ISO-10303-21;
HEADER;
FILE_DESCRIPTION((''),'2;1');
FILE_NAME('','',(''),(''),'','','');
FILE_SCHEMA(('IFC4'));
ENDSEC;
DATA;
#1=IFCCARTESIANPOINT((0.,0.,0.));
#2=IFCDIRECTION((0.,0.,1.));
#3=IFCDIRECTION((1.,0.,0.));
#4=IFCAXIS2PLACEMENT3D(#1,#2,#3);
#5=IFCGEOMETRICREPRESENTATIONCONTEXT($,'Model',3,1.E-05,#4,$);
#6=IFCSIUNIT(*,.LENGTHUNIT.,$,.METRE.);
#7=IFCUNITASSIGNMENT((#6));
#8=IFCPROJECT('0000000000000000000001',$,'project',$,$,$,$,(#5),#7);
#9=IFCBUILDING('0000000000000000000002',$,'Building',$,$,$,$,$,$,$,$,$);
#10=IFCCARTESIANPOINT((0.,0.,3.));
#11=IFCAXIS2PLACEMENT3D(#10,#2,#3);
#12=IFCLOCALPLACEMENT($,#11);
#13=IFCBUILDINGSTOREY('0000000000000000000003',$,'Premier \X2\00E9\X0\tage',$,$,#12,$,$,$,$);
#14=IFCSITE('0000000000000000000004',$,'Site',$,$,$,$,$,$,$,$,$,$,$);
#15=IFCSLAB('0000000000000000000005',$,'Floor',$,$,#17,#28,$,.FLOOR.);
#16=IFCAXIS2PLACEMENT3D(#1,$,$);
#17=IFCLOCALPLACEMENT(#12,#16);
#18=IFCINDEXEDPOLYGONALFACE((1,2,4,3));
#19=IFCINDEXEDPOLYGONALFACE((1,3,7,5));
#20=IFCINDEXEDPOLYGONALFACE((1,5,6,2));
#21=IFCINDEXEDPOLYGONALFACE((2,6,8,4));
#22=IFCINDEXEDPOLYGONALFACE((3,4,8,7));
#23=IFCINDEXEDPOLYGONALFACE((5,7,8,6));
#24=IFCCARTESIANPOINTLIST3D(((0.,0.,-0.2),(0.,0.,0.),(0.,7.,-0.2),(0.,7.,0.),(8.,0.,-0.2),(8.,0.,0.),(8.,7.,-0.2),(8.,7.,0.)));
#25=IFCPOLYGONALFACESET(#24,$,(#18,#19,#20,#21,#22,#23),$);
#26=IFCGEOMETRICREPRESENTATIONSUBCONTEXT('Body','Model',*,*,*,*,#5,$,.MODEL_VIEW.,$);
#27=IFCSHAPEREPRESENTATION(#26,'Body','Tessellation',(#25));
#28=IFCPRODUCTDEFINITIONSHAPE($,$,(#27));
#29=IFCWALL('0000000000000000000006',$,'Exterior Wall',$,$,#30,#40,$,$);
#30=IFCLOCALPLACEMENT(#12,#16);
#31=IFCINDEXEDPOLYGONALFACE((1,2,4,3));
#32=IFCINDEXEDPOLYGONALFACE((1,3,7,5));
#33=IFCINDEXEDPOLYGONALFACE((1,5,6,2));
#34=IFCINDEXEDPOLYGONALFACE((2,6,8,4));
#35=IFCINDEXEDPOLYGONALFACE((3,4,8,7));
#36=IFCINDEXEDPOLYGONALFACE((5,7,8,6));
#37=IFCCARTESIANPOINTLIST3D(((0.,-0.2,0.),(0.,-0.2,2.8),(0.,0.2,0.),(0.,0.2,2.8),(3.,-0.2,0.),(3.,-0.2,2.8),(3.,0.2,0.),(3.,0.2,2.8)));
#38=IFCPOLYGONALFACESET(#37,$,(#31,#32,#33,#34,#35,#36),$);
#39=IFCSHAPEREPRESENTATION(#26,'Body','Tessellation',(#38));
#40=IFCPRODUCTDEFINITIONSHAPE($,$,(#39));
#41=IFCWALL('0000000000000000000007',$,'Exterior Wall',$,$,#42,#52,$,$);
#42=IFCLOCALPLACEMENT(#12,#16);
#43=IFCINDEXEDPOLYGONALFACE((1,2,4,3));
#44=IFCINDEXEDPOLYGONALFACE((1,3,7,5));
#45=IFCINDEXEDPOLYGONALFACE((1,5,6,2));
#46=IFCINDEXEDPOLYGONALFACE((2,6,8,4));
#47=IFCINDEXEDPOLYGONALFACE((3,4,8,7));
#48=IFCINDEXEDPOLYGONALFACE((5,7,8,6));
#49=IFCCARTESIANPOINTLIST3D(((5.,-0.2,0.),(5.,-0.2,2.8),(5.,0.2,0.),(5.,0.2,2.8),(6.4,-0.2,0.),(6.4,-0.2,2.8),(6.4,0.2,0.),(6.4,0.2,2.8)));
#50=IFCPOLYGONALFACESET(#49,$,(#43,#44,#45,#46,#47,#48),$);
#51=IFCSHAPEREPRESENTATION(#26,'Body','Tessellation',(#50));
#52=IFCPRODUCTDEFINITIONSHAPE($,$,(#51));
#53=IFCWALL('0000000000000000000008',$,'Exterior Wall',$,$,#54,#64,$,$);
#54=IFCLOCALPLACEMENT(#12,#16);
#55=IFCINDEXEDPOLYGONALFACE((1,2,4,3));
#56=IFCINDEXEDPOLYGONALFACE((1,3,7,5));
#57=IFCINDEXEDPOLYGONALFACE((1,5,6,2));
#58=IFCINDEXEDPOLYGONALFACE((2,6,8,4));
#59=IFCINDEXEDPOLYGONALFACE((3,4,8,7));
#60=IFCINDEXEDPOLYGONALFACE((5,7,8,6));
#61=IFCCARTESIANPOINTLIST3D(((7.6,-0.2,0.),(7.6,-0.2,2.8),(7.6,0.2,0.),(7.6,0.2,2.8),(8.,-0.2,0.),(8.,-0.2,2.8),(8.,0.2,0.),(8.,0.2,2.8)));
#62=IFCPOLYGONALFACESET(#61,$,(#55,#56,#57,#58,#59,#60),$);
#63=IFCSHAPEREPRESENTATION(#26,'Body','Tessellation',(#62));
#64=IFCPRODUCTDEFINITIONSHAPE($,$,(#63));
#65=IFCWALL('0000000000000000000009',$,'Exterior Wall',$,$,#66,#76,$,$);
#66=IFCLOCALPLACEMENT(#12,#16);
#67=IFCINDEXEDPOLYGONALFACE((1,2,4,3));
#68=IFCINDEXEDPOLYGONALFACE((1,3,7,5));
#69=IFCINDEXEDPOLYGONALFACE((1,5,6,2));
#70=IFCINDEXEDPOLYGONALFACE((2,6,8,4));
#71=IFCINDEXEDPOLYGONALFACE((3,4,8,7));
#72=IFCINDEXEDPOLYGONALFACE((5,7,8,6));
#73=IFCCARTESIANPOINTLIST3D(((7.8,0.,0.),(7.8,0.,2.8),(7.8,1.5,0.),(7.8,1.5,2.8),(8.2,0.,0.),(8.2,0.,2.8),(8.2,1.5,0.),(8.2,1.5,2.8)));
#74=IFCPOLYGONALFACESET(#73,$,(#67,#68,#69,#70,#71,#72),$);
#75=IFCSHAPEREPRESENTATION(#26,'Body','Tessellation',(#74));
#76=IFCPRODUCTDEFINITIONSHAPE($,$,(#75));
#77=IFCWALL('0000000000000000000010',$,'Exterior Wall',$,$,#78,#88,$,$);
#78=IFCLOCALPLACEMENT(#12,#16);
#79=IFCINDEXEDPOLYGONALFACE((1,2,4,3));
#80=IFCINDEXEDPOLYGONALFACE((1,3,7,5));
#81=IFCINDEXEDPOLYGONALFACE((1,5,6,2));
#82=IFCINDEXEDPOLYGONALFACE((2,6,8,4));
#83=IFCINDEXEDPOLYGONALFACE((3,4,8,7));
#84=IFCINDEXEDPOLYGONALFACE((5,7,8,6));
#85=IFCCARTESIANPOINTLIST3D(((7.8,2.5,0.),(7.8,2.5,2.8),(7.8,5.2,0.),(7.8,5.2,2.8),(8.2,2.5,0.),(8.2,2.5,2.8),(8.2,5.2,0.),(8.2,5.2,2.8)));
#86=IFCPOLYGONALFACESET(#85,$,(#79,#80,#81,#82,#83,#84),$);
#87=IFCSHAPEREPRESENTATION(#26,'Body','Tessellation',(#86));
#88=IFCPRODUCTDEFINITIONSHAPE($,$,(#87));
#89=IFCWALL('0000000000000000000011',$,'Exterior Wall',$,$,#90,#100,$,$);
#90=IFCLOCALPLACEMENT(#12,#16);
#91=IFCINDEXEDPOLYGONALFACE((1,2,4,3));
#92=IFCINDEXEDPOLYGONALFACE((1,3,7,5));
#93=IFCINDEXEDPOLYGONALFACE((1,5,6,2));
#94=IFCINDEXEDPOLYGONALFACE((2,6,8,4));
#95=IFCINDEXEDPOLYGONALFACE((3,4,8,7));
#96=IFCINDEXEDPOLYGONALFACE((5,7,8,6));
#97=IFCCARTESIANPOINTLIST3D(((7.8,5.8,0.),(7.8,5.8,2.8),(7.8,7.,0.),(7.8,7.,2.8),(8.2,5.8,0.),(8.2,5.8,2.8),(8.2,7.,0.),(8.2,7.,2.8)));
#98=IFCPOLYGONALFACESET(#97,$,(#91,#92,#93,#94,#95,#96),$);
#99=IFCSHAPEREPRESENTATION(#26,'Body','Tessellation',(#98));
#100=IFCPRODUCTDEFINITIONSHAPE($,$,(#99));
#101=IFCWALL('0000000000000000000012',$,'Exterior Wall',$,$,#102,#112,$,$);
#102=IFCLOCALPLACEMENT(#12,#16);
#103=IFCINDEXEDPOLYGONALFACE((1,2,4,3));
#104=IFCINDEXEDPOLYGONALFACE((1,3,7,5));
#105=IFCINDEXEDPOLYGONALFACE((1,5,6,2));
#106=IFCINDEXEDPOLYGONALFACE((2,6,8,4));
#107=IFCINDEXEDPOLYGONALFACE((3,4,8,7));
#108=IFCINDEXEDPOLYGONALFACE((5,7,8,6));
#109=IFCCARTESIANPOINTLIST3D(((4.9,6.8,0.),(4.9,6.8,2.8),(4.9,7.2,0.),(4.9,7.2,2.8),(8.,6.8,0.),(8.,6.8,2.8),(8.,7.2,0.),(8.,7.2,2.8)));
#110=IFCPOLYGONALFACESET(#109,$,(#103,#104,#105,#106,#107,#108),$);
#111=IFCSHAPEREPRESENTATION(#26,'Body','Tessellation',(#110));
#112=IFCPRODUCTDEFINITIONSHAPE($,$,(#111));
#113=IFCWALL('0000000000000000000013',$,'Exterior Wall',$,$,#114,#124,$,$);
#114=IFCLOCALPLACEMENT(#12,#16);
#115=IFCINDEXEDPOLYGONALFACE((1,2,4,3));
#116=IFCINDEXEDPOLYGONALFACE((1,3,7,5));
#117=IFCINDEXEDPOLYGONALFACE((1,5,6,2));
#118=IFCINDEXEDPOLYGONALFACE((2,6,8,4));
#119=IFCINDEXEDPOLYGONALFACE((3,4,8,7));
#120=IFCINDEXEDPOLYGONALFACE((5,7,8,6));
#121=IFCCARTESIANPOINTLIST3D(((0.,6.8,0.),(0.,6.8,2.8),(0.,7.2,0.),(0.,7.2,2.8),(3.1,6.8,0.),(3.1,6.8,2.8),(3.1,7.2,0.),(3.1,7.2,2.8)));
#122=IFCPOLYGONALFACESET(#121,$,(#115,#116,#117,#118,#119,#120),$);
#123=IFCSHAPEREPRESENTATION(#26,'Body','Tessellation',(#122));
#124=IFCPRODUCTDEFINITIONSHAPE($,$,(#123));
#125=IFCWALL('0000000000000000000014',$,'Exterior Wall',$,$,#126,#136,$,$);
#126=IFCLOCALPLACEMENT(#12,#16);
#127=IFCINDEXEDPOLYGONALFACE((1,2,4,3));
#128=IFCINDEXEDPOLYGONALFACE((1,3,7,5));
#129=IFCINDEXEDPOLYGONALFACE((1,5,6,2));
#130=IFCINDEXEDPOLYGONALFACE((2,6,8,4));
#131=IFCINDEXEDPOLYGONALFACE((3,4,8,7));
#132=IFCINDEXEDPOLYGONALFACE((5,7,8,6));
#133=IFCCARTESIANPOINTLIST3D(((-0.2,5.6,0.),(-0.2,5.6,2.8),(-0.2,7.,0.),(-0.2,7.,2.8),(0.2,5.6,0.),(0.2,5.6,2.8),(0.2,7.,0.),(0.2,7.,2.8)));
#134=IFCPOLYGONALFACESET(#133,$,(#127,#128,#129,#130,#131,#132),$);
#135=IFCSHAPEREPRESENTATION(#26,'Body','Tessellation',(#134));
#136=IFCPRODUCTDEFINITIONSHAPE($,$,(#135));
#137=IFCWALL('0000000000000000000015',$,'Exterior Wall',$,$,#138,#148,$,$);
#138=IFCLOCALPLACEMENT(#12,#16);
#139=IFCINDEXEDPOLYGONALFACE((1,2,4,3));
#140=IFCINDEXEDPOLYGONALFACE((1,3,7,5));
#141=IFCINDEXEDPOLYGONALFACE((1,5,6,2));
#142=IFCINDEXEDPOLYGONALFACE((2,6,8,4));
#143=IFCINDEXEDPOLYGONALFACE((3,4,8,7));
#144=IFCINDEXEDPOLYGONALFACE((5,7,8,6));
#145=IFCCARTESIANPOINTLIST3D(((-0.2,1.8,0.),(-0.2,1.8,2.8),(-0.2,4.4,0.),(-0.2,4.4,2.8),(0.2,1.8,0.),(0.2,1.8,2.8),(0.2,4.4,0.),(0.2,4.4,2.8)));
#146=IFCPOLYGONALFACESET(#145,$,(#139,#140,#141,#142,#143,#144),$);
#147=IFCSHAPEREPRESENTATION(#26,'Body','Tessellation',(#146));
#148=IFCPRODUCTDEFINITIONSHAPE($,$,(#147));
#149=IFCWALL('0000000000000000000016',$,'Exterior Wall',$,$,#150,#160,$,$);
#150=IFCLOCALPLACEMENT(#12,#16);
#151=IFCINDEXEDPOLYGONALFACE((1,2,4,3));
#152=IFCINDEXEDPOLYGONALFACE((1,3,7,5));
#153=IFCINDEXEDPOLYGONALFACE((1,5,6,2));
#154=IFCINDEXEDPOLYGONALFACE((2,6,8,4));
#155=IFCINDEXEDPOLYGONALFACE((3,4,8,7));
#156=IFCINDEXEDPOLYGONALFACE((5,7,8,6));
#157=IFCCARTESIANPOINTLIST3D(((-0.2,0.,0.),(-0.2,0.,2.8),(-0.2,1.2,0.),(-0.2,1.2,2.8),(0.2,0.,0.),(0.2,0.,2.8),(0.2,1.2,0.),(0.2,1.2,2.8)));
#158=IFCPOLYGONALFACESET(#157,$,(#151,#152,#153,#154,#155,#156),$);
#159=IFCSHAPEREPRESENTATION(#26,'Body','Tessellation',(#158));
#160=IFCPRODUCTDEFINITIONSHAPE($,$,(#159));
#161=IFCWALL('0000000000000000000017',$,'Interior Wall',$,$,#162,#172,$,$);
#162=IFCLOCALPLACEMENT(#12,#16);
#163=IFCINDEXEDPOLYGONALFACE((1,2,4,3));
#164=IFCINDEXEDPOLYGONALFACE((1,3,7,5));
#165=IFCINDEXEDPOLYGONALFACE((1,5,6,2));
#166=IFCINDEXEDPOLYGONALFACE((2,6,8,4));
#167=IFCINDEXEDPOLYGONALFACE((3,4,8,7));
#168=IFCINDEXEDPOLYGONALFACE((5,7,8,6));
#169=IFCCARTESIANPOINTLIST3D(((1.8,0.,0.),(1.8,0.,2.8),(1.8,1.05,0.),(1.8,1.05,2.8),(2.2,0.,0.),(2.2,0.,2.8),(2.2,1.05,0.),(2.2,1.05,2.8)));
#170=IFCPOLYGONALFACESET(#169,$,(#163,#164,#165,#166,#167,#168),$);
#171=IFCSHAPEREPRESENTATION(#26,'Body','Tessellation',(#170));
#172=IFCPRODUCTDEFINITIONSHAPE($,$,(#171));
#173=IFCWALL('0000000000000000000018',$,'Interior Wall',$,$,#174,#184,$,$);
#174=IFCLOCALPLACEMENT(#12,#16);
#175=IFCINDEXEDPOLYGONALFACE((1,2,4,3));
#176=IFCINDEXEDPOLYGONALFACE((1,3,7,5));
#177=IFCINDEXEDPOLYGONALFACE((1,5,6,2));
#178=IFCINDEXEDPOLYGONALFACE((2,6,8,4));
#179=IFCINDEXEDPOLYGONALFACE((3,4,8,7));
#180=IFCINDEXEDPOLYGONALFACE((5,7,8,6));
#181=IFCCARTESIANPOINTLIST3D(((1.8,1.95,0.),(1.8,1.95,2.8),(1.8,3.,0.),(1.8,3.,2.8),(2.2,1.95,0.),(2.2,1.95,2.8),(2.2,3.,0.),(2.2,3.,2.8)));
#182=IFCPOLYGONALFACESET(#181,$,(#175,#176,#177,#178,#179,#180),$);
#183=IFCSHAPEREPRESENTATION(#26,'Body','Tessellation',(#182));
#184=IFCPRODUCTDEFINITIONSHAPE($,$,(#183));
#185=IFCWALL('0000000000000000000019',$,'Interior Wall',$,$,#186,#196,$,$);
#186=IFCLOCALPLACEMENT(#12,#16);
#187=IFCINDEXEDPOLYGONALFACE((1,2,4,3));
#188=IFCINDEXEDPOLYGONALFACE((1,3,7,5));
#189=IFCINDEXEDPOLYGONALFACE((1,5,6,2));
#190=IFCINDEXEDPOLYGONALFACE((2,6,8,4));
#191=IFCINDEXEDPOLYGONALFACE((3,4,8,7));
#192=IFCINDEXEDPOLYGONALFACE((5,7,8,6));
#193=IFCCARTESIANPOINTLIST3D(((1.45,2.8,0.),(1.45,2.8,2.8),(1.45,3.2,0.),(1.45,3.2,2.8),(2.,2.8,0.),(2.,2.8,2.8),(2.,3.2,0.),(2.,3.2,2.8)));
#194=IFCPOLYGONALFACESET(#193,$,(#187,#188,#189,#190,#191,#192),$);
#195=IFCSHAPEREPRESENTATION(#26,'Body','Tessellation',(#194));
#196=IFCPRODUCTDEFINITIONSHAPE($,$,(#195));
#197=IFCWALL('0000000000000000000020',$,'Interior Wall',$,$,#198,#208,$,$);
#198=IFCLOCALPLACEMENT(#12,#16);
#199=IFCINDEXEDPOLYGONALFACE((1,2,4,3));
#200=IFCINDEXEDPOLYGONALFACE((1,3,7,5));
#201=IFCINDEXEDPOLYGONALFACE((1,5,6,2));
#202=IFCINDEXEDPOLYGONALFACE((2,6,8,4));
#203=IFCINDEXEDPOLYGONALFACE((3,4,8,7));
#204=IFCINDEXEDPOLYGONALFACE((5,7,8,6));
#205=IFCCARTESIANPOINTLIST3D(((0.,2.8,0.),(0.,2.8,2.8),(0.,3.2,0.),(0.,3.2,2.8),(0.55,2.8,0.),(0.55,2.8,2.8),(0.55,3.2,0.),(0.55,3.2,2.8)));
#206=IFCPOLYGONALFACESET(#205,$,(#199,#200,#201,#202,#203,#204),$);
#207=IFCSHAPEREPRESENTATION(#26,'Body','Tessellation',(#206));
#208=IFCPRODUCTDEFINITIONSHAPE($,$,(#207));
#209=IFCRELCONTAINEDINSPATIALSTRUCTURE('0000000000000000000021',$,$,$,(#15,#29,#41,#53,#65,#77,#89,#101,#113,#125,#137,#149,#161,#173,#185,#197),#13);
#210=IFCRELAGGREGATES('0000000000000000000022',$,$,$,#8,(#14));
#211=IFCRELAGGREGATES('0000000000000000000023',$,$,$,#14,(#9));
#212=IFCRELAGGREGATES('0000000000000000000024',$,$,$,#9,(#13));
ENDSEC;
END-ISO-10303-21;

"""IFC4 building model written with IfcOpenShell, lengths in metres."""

from ifc_helpers import new_model, si_unit, frame, origin_with_axes, place, context, subcontext, project, spatial, indexed_curve, outline, extrude, element, save


model = new_model("IFC4")

# Units and contexts
model_context = context("Model", 3, precision=1e-05, world=origin_with_axes())
body_context = subcontext(model_context, "Body", "Model", "MODEL_VIEW")
ifc_project = project(units=[si_unit("LENGTHUNIT", "METRE")], contexts=[model_context])

# Site, building, storey
site = spatial("IfcSite", under=ifc_project, Name="Site")
building = spatial("IfcBuilding", under=site, Name="Building")
storey_placement = place(None, frame((0.0, 0.0, 3.0), z_axis=(0.0, 0.0, 1.0), x_axis=(1.0, 0.0, 0.0)))
storey = spatial("IfcBuildingStorey", under=building, at=storey_placement, Name="Premier étage")

# Slab
slab_placement = place(storey_placement, frame((0.0, 0.0, -0.2), z_axis=(0.0, 0.0, 1.0), x_axis=(1.0, 0.0, 0.0)))
element("IfcSlab", 1, at=slab_placement, inside=storey, Name="Floor", PredefinedType="FLOOR", context=body_context, shape_type="SweptSolid", body=[
    extrude(outline(indexed_curve([(0.0, 0.0), (8.0, 0.0), (8.0, 7.0), (0.0, 7.0)])), None, (0.0, 0.0, 1.0), 0.2),
])

# Walls
wall_1_placement = place(storey_placement, origin_with_axes())
element("IfcWall", 2, at=wall_1_placement, inside=storey, Name="Exterior Wall", context=body_context, shape_type="SweptSolid", body=[
    extrude(outline(indexed_curve([(0.0, 0.0), (0.0, 0.4), (3.0, 0.4), (3.0, 0.0), (0.0, 0.0)], self_intersect=False)), frame((0.0, -0.2, 0.0), z_axis=(0.0, 0.0, 1.0), x_axis=(1.0, 0.0, 0.0)), (0.0, 0.0, 1.0), 2.8),
])
wall_2_placement = place(storey_placement, frame((5.0, 0.0, 0.0), z_axis=(0.0, 0.0, 1.0), x_axis=(1.0, 0.0, 0.0)))
element("IfcWall", 3, at=wall_2_placement, inside=storey, Name="Exterior Wall", context=body_context, shape_type="SweptSolid", body=[
    extrude(outline(indexed_curve([(0.0, 0.0), (0.0, 0.4), (1.4, 0.4), (1.4, 0.0), (0.0, 0.0)], self_intersect=False)), frame((0.0, -0.2, 0.0), z_axis=(0.0, 0.0, 1.0), x_axis=(1.0, 0.0, 0.0)), (0.0, 0.0, 1.0), 2.8),
])
wall_3_placement = place(storey_placement, frame((7.6, 0.0, 0.0), z_axis=(0.0, 0.0, 1.0), x_axis=(1.0, 0.0, 0.0)))
element("IfcWall", 4, at=wall_3_placement, inside=storey, Name="Exterior Wall", context=body_context, shape_type="SweptSolid", body=[
    extrude(outline(indexed_curve([(0.0, 0.0), (0.0, 0.4), (0.4, 0.4), (0.4, 0.0), (0.0, 0.0)], self_intersect=False)), frame((0.0, -0.2, 0.0), z_axis=(0.0, 0.0, 1.0), x_axis=(1.0, 0.0, 0.0)), (0.0, 0.0, 1.0), 2.8),
])
wall_4_placement = place(storey_placement, frame((8.0, 0.0, 0.0), z_axis=(0.0, 0.0, 1.0), x_axis=(0.0, 1.0, 0.0)))
element("IfcWall", 5, at=wall_4_placement, inside=storey, Name="Exterior Wall", context=body_context, shape_type="SweptSolid", body=[
    extrude(outline(indexed_curve([(0.0, 0.0), (0.0, 0.4), (1.5, 0.4), (1.5, 0.0), (0.0, 0.0)], self_intersect=False)), frame((0.0, -0.2, 0.0), z_axis=(0.0, 0.0, 1.0), x_axis=(1.0, 0.0, 0.0)), (0.0, 0.0, 1.0), 2.8),
])
wall_5_placement = place(storey_placement, frame((8.0, 2.5, 0.0), z_axis=(0.0, 0.0, 1.0), x_axis=(0.0, 1.0, 0.0)))
element("IfcWall", 6, at=wall_5_placement, inside=storey, Name="Exterior Wall", context=body_context, shape_type="SweptSolid", body=[
    extrude(outline(indexed_curve([(0.0, 0.0), (0.0, 0.4), (2.7, 0.4), (2.7, 0.0), (0.0, 0.0)], self_intersect=False)), frame((0.0, -0.2, 0.0), z_axis=(0.0, 0.0, 1.0), x_axis=(1.0, 0.0, 0.0)), (0.0, 0.0, 1.0), 2.8),
])
wall_6_placement = place(storey_placement, frame((8.0, 5.8, 0.0), z_axis=(0.0, 0.0, 1.0), x_axis=(0.0, 1.0, 0.0)))
element("IfcWall", 7, at=wall_6_placement, inside=storey, Name="Exterior Wall", context=body_context, shape_type="SweptSolid", body=[
    extrude(outline(indexed_curve([(0.0, 0.0), (0.0, 0.4), (1.2, 0.4), (1.2, 0.0), (0.0, 0.0)], self_intersect=False)), frame((0.0, -0.2, 0.0), z_axis=(0.0, 0.0, 1.0), x_axis=(1.0, 0.0, 0.0)), (0.0, 0.0, 1.0), 2.8),
])
for number, where, z_axis, x_axis, name in (
    (8, (8.0, 7.0, 0.0), (0.0, 0.0, 1.0), (-1.0, 0.0, 0.0), "Exterior Wall"),
    (9, (3.1, 7.0, 0.0), (0.0, 0.0, 1.0), (-1.0, 0.0, 0.0), "Exterior Wall"),
):
    element("IfcWall", number, at=place(storey_placement, frame(where, z_axis=z_axis, x_axis=x_axis)), inside=storey, Name=name, context=body_context, shape_type="SweptSolid", body=[
        extrude(outline(indexed_curve([(0.0, 0.0), (0.0, 0.4), (3.1, 0.4), (3.1, 0.0), (0.0, 0.0)], self_intersect=False)), frame((0.0, -0.2, 0.0), z_axis=(0.0, 0.0, 1.0), x_axis=(1.0, 0.0, 0.0)), (0.0, 0.0, 1.0), 2.8),
    ])
wall_7_placement = place(storey_placement, frame((0.0, 7.0, 0.0), z_axis=(0.0, 0.0, 1.0), x_axis=(0.0, -1.0, 0.0)))
element("IfcWall", 10, at=wall_7_placement, inside=storey, Name="Exterior Wall", context=body_context, shape_type="SweptSolid", body=[
    extrude(outline(indexed_curve([(0.0, 0.0), (0.0, 0.4), (1.4, 0.4), (1.4, 0.0), (0.0, 0.0)], self_intersect=False)), frame((0.0, -0.2, 0.0), z_axis=(0.0, 0.0, 1.0), x_axis=(1.0, 0.0, 0.0)), (0.0, 0.0, 1.0), 2.8),
])
wall_8_placement = place(storey_placement, frame((0.0, 4.4, 0.0), z_axis=(0.0, 0.0, 1.0), x_axis=(0.0, -1.0, 0.0)))
element("IfcWall", 11, at=wall_8_placement, inside=storey, Name="Exterior Wall", context=body_context, shape_type="SweptSolid", body=[
    extrude(outline(indexed_curve([(0.0, 0.0), (0.0, 0.4), (2.6, 0.4), (2.6, 0.0), (0.0, 0.0)], self_intersect=False)), frame((0.0, -0.2, 0.0), z_axis=(0.0, 0.0, 1.0), x_axis=(1.0, 0.0, 0.0)), (0.0, 0.0, 1.0), 2.8),
])
wall_9_placement = place(storey_placement, frame((0.0, 1.2, 0.0), z_axis=(0.0, 0.0, 1.0), x_axis=(0.0, -1.0, 0.0)))
element("IfcWall", 12, at=wall_9_placement, inside=storey, Name="Exterior Wall", context=body_context, shape_type="SweptSolid", body=[
    extrude(outline(indexed_curve([(0.0, 0.0), (0.0, 0.4), (1.2, 0.4), (1.2, 0.0), (0.0, 0.0)], self_intersect=False)), frame((0.0, -0.2, 0.0), z_axis=(0.0, 0.0, 1.0), x_axis=(1.0, 0.0, 0.0)), (0.0, 0.0, 1.0), 2.8),
])
for number, where, z_axis, x_axis, name in (
    (13, (2.0, 0.0, 0.0), (0.0, 0.0, 1.0), (0.0, 1.0, 0.0), "Interior Wall"),
    (14, (2.0, 1.95, 0.0), (0.0, 0.0, 1.0), (0.0, 1.0, 0.0), "Interior Wall"),
):
    element("IfcWall", number, at=place(storey_placement, frame(where, z_axis=z_axis, x_axis=x_axis)), inside=storey, Name=name, context=body_context, shape_type="SweptSolid", body=[
        extrude(outline(indexed_curve([(0.0, 0.0), (0.0, 0.4), (1.05, 0.4), (1.05, 0.0), (0.0, 0.0)], self_intersect=False)), frame((0.0, -0.2, 0.0), z_axis=(0.0, 0.0, 1.0), x_axis=(1.0, 0.0, 0.0)), (0.0, 0.0, 1.0), 2.8),
    ])
for number, where, z_axis, x_axis, name in (
    (15, (2.0, 3.0, 0.0), (0.0, 0.0, 1.0), (-1.0, 0.0, 0.0), "Interior Wall"),
    (16, (0.55, 3.0, 0.0), (0.0, 0.0, 1.0), (-1.0, 0.0, 0.0), "Interior Wall"),
):
    element("IfcWall", number, at=place(storey_placement, frame(where, z_axis=z_axis, x_axis=x_axis)), inside=storey, Name=name, context=body_context, shape_type="SweptSolid", body=[
        extrude(outline(indexed_curve([(0.0, 0.0), (0.0, 0.4), (0.55, 0.4), (0.55, 0.0), (0.0, 0.0)], self_intersect=False)), frame((0.0, -0.2, 0.0), z_axis=(0.0, 0.0, 1.0), x_axis=(1.0, 0.0, 0.0)), (0.0, 0.0, 1.0), 2.8),
    ])

save(model, "model.ifc")
